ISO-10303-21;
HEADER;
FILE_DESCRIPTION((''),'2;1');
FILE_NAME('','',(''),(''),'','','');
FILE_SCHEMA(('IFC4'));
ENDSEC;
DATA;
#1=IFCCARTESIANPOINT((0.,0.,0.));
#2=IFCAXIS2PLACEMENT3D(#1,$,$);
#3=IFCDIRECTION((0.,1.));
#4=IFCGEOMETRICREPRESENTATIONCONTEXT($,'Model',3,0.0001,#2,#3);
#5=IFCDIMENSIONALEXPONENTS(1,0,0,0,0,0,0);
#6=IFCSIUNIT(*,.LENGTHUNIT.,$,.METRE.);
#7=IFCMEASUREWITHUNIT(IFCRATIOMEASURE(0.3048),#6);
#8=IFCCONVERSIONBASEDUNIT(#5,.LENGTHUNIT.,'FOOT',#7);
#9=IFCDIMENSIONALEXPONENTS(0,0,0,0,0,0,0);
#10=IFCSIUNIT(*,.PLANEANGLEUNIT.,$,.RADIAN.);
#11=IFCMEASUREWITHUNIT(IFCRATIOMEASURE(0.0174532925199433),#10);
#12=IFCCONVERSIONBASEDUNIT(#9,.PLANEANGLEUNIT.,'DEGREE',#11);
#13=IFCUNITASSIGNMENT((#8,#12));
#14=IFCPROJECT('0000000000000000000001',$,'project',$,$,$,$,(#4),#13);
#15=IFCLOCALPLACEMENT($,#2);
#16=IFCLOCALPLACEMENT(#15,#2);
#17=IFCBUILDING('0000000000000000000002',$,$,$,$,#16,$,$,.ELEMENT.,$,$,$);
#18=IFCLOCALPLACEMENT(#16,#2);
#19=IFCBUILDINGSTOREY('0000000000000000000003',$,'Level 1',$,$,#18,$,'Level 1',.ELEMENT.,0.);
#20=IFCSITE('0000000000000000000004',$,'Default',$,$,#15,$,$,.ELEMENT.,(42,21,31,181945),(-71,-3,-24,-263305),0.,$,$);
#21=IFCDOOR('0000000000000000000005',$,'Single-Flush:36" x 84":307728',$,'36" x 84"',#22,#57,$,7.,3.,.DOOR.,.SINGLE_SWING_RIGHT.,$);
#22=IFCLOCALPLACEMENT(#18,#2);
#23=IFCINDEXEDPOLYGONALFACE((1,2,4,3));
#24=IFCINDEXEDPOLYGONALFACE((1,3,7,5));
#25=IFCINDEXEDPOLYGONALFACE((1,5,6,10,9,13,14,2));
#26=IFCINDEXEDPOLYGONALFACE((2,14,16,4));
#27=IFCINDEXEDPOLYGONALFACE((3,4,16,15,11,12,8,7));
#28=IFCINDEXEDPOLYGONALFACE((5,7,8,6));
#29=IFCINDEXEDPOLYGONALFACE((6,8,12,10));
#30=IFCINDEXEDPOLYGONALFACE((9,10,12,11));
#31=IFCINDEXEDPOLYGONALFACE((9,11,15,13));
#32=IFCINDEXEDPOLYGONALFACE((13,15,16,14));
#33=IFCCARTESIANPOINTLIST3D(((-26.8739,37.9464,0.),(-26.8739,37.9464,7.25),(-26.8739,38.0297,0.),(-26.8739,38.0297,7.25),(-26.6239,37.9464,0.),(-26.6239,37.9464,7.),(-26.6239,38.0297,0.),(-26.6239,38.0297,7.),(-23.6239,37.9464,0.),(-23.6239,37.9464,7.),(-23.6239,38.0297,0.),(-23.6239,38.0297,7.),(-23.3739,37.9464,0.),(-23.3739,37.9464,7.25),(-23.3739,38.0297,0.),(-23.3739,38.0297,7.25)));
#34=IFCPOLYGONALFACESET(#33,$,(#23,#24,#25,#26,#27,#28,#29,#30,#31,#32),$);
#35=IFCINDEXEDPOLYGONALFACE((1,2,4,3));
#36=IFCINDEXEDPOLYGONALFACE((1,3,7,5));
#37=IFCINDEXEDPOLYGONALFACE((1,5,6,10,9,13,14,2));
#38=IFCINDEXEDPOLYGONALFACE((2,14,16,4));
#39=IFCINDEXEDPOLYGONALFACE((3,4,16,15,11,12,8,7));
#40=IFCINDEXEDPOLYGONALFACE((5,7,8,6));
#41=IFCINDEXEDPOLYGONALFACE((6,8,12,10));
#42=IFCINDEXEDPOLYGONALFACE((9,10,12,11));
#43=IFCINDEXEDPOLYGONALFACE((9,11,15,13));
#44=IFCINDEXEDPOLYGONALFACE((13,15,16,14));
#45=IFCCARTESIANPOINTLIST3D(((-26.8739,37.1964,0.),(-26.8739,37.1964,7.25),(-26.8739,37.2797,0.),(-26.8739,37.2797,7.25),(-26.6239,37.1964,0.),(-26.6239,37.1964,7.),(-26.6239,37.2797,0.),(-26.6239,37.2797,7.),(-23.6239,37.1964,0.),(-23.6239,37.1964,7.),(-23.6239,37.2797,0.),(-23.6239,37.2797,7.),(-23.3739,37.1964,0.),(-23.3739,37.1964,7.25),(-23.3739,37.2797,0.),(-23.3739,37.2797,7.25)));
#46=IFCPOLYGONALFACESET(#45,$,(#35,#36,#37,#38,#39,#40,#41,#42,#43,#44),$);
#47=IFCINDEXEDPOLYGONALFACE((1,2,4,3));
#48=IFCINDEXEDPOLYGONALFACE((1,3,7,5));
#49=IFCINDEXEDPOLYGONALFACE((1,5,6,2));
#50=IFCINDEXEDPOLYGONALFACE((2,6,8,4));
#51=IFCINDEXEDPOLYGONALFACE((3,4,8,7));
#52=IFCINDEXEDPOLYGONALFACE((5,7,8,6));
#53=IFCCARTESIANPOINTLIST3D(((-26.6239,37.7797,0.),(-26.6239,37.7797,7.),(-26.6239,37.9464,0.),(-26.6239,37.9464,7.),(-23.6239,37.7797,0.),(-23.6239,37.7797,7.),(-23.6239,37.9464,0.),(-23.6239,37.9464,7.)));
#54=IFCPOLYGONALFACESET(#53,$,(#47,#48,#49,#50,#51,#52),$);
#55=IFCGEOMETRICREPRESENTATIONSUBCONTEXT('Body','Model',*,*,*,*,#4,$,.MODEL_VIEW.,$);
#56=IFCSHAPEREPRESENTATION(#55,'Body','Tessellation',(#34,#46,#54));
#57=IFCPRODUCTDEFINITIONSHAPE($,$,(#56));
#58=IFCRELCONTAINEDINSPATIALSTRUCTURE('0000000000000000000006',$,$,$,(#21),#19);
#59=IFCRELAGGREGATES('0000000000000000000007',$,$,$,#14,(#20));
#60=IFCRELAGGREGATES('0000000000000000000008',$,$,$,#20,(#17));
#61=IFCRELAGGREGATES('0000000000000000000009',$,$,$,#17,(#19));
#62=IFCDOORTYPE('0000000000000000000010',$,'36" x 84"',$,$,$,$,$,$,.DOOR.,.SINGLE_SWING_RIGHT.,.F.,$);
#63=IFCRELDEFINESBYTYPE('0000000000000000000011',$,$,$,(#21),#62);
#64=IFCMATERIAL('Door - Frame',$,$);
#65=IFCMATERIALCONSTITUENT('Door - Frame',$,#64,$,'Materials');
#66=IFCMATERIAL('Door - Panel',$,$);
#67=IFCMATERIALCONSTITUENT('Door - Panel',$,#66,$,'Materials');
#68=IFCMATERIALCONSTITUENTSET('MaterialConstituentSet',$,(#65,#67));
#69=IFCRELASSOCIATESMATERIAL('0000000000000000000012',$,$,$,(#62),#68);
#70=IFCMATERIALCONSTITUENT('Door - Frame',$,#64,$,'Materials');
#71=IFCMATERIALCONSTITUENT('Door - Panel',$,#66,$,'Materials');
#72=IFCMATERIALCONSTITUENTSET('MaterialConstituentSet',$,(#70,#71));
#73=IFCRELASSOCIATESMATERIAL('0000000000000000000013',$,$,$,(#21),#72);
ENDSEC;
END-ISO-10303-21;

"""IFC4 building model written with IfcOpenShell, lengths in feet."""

from ifc_helpers import new_model, entity, si_unit, converted_unit, direction, frame, frame_2d, origin, place, context, subcontext, project, spatial, polyline, rectangle, outline, extrude, source, transform, mapped, material, constituent, constituent_set, type_object, type_shapes, element, save


model = new_model("IFC4")

# Units and contexts
model_context = context("Model", 3, precision=0.0001, world=origin(), true_north=direction((0.0, 1.0)))
body_context = subcontext(model_context, "Body", "Model", "MODEL_VIEW")
ifc_project = project(units=[converted_unit("LENGTHUNIT", "FOOT", entity("IfcRatioMeasure", 0.3048), si_unit("LENGTHUNIT", "METRE"), dimensions=[1, 0, 0, 0, 0, 0, 0]), converted_unit("PLANEANGLEUNIT", "DEGREE", entity("IfcRatioMeasure", 0.0174532925199433), si_unit("PLANEANGLEUNIT", "RADIAN"), dimensions=[0, 0, 0, 0, 0, 0, 0])], contexts=[model_context])

# Site, building, storey
site_placement = place(None, origin())
site = spatial("IfcSite", under=ifc_project, at=site_placement, Name="Default", CompositionType="ELEMENT", RefLatitude=(42, 21, 31, 181945), RefLongitude=(-71, -3, -24, -263305), RefElevation=0.0)
building_placement = place(site_placement, origin())
building = spatial("IfcBuilding", under=site, at=building_placement, CompositionType="ELEMENT")
storey_placement = place(building_placement, origin())
storey = spatial("IfcBuildingStorey", under=building, at=storey_placement, Name="Level 1", LongName="Level 1", CompositionType="ELEMENT", Elevation=0.0)

# Shared definitions
placement_1 = place(storey_placement, frame((-21.2906, 37.6131, 0.0), z_axis=(0.0, 0.0, 1.0), x_axis=(-1.0, 0.0, 0.0)))

# Door
ifc_material_1 = material(Name="Door - Frame")
ifc_constituent_1 = constituent(ifc_material_1, Name="Door - Frame", Category="Materials")
ifc_material_2 = material(Name="Door - Panel")
ifc_constituent_2 = constituent(ifc_material_2, Name="Door - Panel", Category="Materials")
ifc_constituent_set_1 = constituent_set(constituents=[ifc_constituent_1, ifc_constituent_2], Name="MaterialConstituentSet")
ifc_constituent_3 = constituent(ifc_material_1, Name="Door - Frame", Category="Materials")
ifc_constituent_4 = constituent(ifc_material_2, Name="Door - Panel", Category="Materials")
ifc_constituent_set_2 = constituent_set(constituents=[ifc_constituent_3, ifc_constituent_4], Name="MaterialConstituentSet")
door_type = type_object("IfcDoorType", Name="36\" x 84\"", OperationType="SINGLE_SWING_RIGHT", ParameterTakesPrecedence=False, PredefinedType="DOOR", material=ifc_constituent_set_2)
shared_shape = source(origin(), body_context, "Body", "SweptSolid", [
    extrude(outline(polyline([(-1.75, -3.6875), (1.75, -3.6875), (1.75, 3.5625), (1.5, 3.5625), (1.5, -3.4375), (-1.5, -3.4375), (-1.5, 3.5625), (-1.75, 3.5625), (-1.75, -3.6875)])), frame((1.5, 0.6667, 3.5625), z_axis=(0.0, 1.0, 0.0), x_axis=(1.0, 0.0, 0.0)), (0.0, 0.0, 1.0), 0.0833),
    extrude(outline(polyline([(-3.6875, -1.75), (3.5625, -1.75), (3.5625, -1.5), (-3.4375, -1.5), (-3.4375, 1.5), (3.5625, 1.5), (3.5625, 1.75), (-3.6875, 1.75), (-3.6875, -1.75)])), frame((1.5, -0.0833, 3.5625), z_axis=(0.0, 1.0, 0.0), x_axis=(0.0, 0.0, -1.0)), (0.0, 0.0, 1.0), 0.0833),
    extrude(rectangle(XDim=0.1667, YDim=3.0, at=frame_2d((0.0, 0.0), x_axis=(1.0, 0.0))), frame((1.5, 0.5833, 0.0), z_axis=(0.0, 0.0, 1.0), x_axis=(0.0, 1.0, 0.0)), (0.0, 0.0, 1.0), 7.0),
])
type_shapes(door_type, [shared_shape])
placement_2 = place(placement_1, frame((5.3333, 0.3333, 0.0)))
door_placement = place(placement_2, frame((0.0, 0.0, 0.0), z_axis=(0.0, 0.0, 1.0), x_axis=(-1.0, 0.0, 0.0)))
element("IfcDoor", 1, at=door_placement, inside=storey, type_object=door_type, material=ifc_constituent_set_1, Name="Single-Flush:36\" x 84\":307728", ObjectType="36\" x 84\"", OperationType="SINGLE_SWING_RIGHT", OverallHeight=7.0, OverallWidth=3.0, PredefinedType="DOOR", context=body_context, shape_type="MappedRepresentation", body=[
    mapped(shared_shape, transform((0.0, 0.0, 0.0), scale=1.0)),
])

save(model, "model.ifc")
